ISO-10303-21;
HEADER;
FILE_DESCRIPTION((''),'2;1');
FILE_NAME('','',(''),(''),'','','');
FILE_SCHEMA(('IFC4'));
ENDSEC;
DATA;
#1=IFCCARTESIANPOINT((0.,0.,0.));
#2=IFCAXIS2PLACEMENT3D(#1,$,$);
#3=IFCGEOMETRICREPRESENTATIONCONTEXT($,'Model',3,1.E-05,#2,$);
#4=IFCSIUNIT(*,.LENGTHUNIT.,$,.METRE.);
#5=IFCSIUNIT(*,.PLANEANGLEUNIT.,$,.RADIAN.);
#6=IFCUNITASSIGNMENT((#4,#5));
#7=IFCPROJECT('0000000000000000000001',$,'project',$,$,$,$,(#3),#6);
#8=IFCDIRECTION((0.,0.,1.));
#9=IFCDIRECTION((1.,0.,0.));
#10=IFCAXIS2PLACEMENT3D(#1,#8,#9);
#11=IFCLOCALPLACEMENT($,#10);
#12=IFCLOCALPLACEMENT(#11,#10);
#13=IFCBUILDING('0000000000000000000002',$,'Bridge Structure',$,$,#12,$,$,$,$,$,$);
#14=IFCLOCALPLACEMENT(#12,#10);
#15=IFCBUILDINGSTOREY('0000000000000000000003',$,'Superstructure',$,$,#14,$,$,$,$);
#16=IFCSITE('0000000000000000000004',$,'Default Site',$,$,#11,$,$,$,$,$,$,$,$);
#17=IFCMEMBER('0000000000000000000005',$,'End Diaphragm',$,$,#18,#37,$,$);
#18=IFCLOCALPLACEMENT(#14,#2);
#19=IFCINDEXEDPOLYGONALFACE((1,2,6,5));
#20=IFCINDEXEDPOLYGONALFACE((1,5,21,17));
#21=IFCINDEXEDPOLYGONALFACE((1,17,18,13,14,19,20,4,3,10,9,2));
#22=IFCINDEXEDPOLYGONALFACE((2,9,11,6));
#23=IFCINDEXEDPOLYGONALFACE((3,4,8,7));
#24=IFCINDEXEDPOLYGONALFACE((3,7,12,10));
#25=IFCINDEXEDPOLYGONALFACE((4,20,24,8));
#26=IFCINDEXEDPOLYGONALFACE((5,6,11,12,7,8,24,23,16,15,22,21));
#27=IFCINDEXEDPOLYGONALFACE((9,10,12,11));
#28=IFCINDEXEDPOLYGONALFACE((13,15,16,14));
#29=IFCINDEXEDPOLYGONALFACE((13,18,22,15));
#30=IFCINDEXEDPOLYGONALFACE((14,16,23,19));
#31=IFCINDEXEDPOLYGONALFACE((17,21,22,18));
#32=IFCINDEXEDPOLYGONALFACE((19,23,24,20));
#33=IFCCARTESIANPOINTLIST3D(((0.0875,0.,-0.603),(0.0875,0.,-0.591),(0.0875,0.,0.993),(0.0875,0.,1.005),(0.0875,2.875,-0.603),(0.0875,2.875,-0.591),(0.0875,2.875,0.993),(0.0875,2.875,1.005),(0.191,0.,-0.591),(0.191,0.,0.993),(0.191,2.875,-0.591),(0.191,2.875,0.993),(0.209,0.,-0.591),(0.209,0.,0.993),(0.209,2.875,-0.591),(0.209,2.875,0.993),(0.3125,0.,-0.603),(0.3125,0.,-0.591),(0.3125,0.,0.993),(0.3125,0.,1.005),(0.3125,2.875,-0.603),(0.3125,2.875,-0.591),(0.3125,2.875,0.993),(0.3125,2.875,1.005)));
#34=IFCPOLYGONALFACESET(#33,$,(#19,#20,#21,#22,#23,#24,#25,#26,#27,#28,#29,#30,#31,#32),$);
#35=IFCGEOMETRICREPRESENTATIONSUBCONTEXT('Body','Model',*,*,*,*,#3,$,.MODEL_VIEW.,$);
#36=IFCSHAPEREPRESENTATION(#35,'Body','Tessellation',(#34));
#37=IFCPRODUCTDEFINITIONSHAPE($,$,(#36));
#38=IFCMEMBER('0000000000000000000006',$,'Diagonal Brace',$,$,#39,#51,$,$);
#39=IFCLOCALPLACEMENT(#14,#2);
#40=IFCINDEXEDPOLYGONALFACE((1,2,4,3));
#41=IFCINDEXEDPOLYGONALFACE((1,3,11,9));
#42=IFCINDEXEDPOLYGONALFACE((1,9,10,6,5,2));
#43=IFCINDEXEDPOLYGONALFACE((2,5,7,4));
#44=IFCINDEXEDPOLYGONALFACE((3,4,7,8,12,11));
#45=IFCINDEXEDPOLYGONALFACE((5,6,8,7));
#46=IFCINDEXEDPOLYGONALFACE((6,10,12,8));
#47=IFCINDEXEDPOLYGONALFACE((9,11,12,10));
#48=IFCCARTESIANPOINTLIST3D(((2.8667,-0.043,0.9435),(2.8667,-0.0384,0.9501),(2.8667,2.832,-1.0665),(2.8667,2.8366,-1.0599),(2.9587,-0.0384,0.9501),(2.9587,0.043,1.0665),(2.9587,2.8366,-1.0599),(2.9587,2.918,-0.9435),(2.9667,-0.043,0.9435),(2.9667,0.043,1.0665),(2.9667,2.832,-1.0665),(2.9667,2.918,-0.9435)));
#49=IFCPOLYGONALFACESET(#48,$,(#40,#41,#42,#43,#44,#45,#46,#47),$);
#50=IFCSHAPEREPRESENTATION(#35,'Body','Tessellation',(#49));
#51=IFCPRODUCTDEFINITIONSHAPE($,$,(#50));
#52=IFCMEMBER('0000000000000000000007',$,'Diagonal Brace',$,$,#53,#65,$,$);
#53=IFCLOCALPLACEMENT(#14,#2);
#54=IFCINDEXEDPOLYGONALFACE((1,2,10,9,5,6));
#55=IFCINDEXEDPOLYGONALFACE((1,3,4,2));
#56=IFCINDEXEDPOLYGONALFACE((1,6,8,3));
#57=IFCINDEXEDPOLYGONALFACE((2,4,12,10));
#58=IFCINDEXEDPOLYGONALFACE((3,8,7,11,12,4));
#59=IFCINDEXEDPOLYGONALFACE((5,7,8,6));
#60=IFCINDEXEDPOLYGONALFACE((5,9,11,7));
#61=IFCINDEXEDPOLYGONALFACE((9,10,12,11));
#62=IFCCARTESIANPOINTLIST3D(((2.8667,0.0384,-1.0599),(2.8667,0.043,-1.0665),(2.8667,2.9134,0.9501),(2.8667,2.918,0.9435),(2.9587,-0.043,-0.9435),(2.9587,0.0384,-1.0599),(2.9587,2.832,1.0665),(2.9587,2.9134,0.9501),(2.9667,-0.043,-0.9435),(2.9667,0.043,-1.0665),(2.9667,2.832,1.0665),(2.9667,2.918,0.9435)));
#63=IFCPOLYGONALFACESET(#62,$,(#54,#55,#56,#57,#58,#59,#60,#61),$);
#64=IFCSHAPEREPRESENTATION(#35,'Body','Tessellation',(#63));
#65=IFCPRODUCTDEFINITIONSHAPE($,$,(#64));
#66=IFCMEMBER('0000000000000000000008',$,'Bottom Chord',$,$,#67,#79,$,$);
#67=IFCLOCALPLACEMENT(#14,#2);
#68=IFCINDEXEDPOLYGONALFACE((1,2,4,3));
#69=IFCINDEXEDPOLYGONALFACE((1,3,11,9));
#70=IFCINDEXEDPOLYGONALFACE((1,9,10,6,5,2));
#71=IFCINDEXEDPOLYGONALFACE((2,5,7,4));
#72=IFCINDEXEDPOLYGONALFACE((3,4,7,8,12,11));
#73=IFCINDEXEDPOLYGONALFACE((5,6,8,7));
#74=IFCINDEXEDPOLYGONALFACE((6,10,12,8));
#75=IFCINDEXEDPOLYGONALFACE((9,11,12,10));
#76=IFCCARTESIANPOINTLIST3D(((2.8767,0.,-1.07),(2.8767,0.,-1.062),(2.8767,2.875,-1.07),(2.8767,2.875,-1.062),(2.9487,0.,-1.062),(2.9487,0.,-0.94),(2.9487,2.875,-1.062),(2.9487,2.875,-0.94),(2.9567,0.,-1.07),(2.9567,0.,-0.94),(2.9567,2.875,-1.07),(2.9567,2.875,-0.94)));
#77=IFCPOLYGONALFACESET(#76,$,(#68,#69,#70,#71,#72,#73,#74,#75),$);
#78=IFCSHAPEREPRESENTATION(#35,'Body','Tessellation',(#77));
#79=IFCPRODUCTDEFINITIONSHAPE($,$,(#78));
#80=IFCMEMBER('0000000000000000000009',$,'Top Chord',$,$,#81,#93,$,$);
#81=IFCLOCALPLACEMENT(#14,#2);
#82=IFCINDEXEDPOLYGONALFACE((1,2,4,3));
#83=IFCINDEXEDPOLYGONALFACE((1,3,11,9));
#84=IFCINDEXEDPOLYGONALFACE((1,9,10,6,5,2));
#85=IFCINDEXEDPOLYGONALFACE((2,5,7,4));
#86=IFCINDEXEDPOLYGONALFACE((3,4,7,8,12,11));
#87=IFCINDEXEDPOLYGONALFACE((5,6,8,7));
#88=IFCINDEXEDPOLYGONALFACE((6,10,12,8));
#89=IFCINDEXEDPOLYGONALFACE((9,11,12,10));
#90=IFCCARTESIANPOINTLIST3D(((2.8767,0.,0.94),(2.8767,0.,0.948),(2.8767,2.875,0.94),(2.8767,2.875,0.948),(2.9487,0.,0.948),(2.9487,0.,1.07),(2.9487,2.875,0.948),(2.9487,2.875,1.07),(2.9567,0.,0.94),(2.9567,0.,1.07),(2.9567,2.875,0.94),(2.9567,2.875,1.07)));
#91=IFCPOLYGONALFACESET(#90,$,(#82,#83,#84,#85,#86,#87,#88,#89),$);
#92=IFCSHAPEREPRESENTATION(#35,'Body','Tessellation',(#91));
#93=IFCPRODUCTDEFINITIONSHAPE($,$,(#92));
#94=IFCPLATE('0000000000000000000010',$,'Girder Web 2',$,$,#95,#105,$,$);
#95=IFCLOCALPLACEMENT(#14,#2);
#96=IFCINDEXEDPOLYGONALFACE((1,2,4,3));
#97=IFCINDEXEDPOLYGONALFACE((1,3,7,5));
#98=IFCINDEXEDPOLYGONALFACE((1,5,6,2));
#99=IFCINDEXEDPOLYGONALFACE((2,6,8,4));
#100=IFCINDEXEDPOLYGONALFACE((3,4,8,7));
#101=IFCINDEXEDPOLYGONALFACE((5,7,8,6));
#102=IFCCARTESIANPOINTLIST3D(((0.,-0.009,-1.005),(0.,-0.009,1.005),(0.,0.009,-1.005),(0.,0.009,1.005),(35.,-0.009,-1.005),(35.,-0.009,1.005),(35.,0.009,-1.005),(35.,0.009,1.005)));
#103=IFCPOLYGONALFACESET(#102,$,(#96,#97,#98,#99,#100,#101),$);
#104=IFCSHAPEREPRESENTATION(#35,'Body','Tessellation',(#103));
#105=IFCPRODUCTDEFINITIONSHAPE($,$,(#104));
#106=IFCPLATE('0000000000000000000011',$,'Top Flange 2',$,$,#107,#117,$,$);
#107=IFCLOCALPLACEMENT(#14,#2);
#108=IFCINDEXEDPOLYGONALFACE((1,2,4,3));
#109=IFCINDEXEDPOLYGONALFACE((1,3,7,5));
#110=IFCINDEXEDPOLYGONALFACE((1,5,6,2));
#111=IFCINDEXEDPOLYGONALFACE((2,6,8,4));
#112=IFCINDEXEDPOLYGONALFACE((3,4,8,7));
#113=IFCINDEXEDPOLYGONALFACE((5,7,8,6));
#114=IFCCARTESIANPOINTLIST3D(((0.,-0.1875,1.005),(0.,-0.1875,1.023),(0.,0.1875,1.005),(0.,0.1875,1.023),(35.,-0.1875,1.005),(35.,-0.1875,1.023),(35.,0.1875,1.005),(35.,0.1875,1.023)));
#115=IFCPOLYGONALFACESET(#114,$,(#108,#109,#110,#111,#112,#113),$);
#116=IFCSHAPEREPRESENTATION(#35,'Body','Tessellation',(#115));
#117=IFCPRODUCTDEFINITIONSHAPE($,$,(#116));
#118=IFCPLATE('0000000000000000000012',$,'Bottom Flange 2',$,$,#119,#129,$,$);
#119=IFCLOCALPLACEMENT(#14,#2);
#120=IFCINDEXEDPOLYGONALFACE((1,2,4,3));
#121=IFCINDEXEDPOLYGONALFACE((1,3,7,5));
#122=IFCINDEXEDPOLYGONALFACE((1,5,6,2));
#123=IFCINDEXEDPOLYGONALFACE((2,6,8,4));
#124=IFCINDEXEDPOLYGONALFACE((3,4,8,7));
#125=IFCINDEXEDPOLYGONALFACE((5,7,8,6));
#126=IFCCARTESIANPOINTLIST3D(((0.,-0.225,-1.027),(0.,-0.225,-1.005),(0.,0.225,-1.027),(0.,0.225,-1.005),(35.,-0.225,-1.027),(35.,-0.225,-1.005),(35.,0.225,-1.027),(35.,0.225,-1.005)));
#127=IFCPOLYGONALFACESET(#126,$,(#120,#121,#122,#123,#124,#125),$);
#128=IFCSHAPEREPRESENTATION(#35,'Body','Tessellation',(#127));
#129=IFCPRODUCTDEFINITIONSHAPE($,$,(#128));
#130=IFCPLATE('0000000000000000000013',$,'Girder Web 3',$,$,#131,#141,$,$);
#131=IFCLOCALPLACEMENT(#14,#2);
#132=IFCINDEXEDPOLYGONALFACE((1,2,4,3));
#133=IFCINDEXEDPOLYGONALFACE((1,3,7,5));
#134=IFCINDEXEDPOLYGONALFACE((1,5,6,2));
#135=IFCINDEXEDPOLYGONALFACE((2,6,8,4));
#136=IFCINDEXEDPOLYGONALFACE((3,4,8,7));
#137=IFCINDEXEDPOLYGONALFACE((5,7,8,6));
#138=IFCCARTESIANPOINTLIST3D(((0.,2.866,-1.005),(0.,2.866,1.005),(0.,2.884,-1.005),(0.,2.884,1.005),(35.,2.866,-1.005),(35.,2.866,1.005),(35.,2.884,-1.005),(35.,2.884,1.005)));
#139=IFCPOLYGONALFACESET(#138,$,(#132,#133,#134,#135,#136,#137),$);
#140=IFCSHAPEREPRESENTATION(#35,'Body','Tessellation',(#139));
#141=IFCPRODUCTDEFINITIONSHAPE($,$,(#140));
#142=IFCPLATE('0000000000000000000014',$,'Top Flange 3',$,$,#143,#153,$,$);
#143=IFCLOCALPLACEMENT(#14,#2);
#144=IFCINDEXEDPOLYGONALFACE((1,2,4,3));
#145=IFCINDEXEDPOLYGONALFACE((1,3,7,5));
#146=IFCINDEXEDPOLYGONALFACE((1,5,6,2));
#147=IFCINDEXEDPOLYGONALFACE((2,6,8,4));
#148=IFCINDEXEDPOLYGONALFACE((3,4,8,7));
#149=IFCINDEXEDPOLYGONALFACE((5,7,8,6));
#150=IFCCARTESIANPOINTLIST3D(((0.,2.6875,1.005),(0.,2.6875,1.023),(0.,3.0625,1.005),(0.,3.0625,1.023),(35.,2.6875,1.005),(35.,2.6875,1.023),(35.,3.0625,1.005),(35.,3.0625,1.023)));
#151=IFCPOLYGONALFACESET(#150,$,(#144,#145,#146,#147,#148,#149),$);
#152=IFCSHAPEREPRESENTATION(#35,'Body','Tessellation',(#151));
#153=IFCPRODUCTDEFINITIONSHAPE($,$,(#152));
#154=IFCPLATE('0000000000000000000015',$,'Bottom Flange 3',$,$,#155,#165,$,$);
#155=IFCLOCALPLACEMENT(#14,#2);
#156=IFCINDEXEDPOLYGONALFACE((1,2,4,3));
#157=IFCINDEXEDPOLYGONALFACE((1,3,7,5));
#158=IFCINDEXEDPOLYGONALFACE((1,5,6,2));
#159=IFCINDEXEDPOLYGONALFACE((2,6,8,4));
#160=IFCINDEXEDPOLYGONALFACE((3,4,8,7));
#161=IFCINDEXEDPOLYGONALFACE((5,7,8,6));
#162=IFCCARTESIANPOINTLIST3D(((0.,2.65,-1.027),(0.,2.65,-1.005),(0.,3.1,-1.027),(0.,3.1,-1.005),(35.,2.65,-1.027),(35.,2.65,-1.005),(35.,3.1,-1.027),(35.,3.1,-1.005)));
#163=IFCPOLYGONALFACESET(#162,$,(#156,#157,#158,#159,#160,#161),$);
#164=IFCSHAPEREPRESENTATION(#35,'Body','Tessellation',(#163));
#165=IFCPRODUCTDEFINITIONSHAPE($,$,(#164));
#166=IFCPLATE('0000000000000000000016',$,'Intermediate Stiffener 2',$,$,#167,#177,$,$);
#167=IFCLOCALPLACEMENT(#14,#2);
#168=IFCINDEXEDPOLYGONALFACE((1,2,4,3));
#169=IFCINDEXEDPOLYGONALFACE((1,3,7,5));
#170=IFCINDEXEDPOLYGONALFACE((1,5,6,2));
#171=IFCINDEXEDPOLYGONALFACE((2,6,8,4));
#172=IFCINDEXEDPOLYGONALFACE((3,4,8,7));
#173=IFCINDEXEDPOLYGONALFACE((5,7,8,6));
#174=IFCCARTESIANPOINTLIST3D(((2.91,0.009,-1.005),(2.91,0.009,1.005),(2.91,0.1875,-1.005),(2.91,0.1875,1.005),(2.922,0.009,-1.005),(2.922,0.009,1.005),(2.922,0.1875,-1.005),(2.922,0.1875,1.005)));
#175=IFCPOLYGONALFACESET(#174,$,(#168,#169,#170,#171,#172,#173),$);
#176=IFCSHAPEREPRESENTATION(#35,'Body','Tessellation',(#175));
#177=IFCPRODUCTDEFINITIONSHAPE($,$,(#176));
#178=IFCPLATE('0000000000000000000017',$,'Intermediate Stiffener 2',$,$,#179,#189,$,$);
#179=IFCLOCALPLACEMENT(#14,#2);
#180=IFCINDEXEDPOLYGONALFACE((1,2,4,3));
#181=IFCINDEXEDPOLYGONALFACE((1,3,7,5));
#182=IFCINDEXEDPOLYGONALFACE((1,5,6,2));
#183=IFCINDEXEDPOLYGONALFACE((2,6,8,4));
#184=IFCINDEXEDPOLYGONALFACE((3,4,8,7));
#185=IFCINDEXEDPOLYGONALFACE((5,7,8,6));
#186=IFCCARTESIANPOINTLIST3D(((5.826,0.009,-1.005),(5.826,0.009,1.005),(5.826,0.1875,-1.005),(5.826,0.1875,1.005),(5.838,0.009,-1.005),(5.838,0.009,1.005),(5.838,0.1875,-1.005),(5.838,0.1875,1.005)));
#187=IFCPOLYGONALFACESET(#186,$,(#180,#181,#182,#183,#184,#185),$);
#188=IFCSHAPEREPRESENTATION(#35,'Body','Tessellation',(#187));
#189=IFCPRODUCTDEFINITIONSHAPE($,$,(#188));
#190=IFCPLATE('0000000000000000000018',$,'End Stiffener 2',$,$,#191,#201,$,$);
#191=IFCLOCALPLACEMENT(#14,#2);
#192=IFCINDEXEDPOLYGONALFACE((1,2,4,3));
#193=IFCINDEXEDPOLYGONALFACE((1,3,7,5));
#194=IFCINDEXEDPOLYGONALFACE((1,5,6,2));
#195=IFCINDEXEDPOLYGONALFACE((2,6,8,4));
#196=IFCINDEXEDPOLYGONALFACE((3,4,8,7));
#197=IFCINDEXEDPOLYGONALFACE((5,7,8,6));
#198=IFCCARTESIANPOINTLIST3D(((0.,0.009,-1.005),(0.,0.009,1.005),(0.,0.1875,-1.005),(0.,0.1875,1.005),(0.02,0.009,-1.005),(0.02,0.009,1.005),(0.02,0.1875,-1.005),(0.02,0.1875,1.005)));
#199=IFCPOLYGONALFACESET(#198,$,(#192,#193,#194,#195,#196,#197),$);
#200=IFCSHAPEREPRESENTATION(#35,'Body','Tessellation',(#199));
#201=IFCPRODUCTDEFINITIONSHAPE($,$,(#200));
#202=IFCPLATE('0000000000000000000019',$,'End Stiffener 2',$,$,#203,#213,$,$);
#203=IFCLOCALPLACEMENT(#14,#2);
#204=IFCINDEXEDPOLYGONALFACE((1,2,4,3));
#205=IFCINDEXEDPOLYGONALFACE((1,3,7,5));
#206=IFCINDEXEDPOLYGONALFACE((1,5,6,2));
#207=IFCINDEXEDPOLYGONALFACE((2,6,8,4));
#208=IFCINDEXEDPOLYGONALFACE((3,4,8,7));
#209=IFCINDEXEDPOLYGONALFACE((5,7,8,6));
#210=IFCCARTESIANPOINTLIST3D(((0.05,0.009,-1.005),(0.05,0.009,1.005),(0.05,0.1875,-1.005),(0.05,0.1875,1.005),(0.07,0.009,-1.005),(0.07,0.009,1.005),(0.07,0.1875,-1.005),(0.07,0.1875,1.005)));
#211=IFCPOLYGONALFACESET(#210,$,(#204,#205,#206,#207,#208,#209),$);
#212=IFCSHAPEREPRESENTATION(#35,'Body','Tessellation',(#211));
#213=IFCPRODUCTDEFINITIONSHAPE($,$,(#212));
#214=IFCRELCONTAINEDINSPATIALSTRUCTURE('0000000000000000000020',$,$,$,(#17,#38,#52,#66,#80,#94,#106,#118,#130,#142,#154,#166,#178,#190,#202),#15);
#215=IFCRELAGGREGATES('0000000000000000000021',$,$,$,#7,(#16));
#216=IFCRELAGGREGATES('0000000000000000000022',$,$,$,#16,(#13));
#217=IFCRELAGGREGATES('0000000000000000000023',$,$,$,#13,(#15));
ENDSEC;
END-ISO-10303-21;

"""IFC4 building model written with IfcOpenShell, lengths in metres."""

from ifc_helpers import new_model, si_unit, frame, origin, origin_with_axes, origin_2d_with_axis, place, context, subcontext, project, spatial, rectangle, i_section, l_section, extrude, element, save


model = new_model("IFC4")

# Units and contexts
model_context = context("Model", 3, precision=1e-05, world=origin())
body_context = subcontext(model_context, "Body", "Model", "MODEL_VIEW")
ifc_project = project(units=[si_unit("LENGTHUNIT", "METRE"), si_unit("PLANEANGLEUNIT", "RADIAN")], contexts=[model_context])

# Site, building, storey
site_placement = place(None, origin_with_axes())
site = spatial("IfcSite", under=ifc_project, at=site_placement, Name="Default Site")
building_placement = place(site_placement, origin_with_axes())
building = spatial("IfcBuilding", under=site, at=building_placement, Name="Bridge Structure")
storey_placement = place(building_placement, origin_with_axes())
storey = spatial("IfcBuildingStorey", under=building, at=storey_placement, Name="Superstructure")

# Members
member_placement = place(storey_placement, frame((0.2, 0.0, 0.201), z_axis=(0.0, 1.0, 0.0), x_axis=(-1.0, 0.0, 0.0)))
element("IfcMember", 1, at=member_placement, inside=storey, Name="End Diaphragm", context=body_context, shape_type="SweptSolid", body=[
    extrude(i_section(OverallWidth=0.225, OverallDepth=1.608, WebThickness=0.018, FlangeThickness=0.012, at=origin_2d_with_axis()), origin_with_axes(), (0.0, 0.0, 1.0), 2.875),
])
for number, where, z_axis, x_axis, name in (
    (2, (2.9167, 0.0, 1.005), (0.0, 0.819567, -0.572984), (-1.0, 0.0, 0.0), "Diagonal Brace"),
    (3, (2.9167, 0.0, -1.005), (0.0, 0.819567, 0.572984), (-1.0, 0.0, 0.0), "Diagonal Brace"),
):
    element("IfcMember", number, at=place(storey_placement, frame(where, z_axis=z_axis, x_axis=x_axis)), inside=storey, Name=name, context=body_context, shape_type="SweptSolid", body=[
        extrude(l_section(Depth=0.15, Width=0.1, Thickness=0.008, at=origin_2d_with_axis()), origin_with_axes(), (0.0, 0.0, 1.0), 3.508),
    ])
for number, where, z_axis, x_axis, name in (
    (4, (2.9167, 0.0, -1.005), (0.0, 1.0, 0.0), (-1.0, 0.0, 0.0), "Bottom Chord"),
    (5, (2.9167, 0.0, 1.005), (0.0, 1.0, 0.0), (-1.0, 0.0, 0.0), "Top Chord"),
):
    element("IfcMember", number, at=place(storey_placement, frame(where, z_axis=z_axis, x_axis=x_axis)), inside=storey, Name=name, context=body_context, shape_type="SweptSolid", body=[
        extrude(l_section(Depth=0.13, Width=0.08, Thickness=0.008, at=origin_2d_with_axis()), origin_with_axes(), (0.0, 0.0, 1.0), 2.875),
    ])

# Plates
plate_1_placement = place(storey_placement, frame((0.0, 0.0, 0.0), z_axis=(1.0, 0.0, 0.0), x_axis=(0.0, 1.0, 0.0)))
element("IfcPlate", 6, at=plate_1_placement, inside=storey, Name="Girder Web 2", context=body_context, shape_type="SweptSolid", body=[
    extrude(rectangle(XDim=0.018, YDim=2.01, at=origin_2d_with_axis()), origin_with_axes(), (0.0, 0.0, 1.0), 35.0),
])
plate_2_placement = place(storey_placement, frame((0.0, 0.0, 1.014), z_axis=(1.0, 0.0, 0.0), x_axis=(0.0, 1.0, 0.0)))
element("IfcPlate", 7, at=plate_2_placement, inside=storey, Name="Top Flange 2", context=body_context, shape_type="SweptSolid", body=[
    extrude(rectangle(XDim=0.375, YDim=0.018, at=origin_2d_with_axis()), origin_with_axes(), (0.0, 0.0, 1.0), 35.0),
])
plate_3_placement = place(storey_placement, frame((0.0, 0.0, -1.016), z_axis=(1.0, 0.0, 0.0), x_axis=(0.0, 1.0, 0.0)))
element("IfcPlate", 8, at=plate_3_placement, inside=storey, Name="Bottom Flange 2", context=body_context, shape_type="SweptSolid", body=[
    extrude(rectangle(XDim=0.45, YDim=0.022, at=origin_2d_with_axis()), origin_with_axes(), (0.0, 0.0, 1.0), 35.0),
])
plate_4_placement = place(storey_placement, frame((0.0, 2.875, 0.0), z_axis=(1.0, 0.0, 0.0), x_axis=(0.0, 1.0, 0.0)))
element("IfcPlate", 9, at=plate_4_placement, inside=storey, Name="Girder Web 3", context=body_context, shape_type="SweptSolid", body=[
    extrude(rectangle(XDim=0.018, YDim=2.01, at=origin_2d_with_axis()), origin_with_axes(), (0.0, 0.0, 1.0), 35.0),
])
plate_5_placement = place(storey_placement, frame((0.0, 2.875, 1.014), z_axis=(1.0, 0.0, 0.0), x_axis=(0.0, 1.0, 0.0)))
element("IfcPlate", 10, at=plate_5_placement, inside=storey, Name="Top Flange 3", context=body_context, shape_type="SweptSolid", body=[
    extrude(rectangle(XDim=0.375, YDim=0.018, at=origin_2d_with_axis()), origin_with_axes(), (0.0, 0.0, 1.0), 35.0),
])
plate_6_placement = place(storey_placement, frame((0.0, 2.875, -1.016), z_axis=(1.0, 0.0, 0.0), x_axis=(0.0, 1.0, 0.0)))
element("IfcPlate", 11, at=plate_6_placement, inside=storey, Name="Bottom Flange 3", context=body_context, shape_type="SweptSolid", body=[
    extrude(rectangle(XDim=0.45, YDim=0.022, at=origin_2d_with_axis()), origin_with_axes(), (0.0, 0.0, 1.0), 35.0),
])
for number, where, z_axis, x_axis, name in (
    (12, (2.916, 0.0983, -1.005), (0.0, 0.0, 1.0), (1.0, 0.0, 0.0), "Intermediate Stiffener 2"),
    (13, (5.832, 0.0983, -1.005), (0.0, 0.0, 1.0), (1.0, 0.0, 0.0), "Intermediate Stiffener 2"),
):
    element("IfcPlate", number, at=place(storey_placement, frame(where, z_axis=z_axis, x_axis=x_axis)), inside=storey, Name=name, context=body_context, shape_type="SweptSolid", body=[
        extrude(rectangle(XDim=0.012, YDim=0.1785, at=origin_2d_with_axis()), origin_with_axes(), (0.0, 0.0, 1.0), 2.01),
    ])
for number, where, z_axis, x_axis, name in (
    (14, (0.01, 0.0983, -1.005), (0.0, 0.0, 1.0), (1.0, 0.0, 0.0), "End Stiffener 2"),
    (15, (0.06, 0.0983, -1.005), (0.0, 0.0, 1.0), (1.0, 0.0, 0.0), "End Stiffener 2"),
):
    element("IfcPlate", number, at=place(storey_placement, frame(where, z_axis=z_axis, x_axis=x_axis)), inside=storey, Name=name, context=body_context, shape_type="SweptSolid", body=[
        extrude(rectangle(XDim=0.02, YDim=0.1785, at=origin_2d_with_axis()), origin_with_axes(), (0.0, 0.0, 1.0), 2.01),
    ])

save(model, "model.ifc")
